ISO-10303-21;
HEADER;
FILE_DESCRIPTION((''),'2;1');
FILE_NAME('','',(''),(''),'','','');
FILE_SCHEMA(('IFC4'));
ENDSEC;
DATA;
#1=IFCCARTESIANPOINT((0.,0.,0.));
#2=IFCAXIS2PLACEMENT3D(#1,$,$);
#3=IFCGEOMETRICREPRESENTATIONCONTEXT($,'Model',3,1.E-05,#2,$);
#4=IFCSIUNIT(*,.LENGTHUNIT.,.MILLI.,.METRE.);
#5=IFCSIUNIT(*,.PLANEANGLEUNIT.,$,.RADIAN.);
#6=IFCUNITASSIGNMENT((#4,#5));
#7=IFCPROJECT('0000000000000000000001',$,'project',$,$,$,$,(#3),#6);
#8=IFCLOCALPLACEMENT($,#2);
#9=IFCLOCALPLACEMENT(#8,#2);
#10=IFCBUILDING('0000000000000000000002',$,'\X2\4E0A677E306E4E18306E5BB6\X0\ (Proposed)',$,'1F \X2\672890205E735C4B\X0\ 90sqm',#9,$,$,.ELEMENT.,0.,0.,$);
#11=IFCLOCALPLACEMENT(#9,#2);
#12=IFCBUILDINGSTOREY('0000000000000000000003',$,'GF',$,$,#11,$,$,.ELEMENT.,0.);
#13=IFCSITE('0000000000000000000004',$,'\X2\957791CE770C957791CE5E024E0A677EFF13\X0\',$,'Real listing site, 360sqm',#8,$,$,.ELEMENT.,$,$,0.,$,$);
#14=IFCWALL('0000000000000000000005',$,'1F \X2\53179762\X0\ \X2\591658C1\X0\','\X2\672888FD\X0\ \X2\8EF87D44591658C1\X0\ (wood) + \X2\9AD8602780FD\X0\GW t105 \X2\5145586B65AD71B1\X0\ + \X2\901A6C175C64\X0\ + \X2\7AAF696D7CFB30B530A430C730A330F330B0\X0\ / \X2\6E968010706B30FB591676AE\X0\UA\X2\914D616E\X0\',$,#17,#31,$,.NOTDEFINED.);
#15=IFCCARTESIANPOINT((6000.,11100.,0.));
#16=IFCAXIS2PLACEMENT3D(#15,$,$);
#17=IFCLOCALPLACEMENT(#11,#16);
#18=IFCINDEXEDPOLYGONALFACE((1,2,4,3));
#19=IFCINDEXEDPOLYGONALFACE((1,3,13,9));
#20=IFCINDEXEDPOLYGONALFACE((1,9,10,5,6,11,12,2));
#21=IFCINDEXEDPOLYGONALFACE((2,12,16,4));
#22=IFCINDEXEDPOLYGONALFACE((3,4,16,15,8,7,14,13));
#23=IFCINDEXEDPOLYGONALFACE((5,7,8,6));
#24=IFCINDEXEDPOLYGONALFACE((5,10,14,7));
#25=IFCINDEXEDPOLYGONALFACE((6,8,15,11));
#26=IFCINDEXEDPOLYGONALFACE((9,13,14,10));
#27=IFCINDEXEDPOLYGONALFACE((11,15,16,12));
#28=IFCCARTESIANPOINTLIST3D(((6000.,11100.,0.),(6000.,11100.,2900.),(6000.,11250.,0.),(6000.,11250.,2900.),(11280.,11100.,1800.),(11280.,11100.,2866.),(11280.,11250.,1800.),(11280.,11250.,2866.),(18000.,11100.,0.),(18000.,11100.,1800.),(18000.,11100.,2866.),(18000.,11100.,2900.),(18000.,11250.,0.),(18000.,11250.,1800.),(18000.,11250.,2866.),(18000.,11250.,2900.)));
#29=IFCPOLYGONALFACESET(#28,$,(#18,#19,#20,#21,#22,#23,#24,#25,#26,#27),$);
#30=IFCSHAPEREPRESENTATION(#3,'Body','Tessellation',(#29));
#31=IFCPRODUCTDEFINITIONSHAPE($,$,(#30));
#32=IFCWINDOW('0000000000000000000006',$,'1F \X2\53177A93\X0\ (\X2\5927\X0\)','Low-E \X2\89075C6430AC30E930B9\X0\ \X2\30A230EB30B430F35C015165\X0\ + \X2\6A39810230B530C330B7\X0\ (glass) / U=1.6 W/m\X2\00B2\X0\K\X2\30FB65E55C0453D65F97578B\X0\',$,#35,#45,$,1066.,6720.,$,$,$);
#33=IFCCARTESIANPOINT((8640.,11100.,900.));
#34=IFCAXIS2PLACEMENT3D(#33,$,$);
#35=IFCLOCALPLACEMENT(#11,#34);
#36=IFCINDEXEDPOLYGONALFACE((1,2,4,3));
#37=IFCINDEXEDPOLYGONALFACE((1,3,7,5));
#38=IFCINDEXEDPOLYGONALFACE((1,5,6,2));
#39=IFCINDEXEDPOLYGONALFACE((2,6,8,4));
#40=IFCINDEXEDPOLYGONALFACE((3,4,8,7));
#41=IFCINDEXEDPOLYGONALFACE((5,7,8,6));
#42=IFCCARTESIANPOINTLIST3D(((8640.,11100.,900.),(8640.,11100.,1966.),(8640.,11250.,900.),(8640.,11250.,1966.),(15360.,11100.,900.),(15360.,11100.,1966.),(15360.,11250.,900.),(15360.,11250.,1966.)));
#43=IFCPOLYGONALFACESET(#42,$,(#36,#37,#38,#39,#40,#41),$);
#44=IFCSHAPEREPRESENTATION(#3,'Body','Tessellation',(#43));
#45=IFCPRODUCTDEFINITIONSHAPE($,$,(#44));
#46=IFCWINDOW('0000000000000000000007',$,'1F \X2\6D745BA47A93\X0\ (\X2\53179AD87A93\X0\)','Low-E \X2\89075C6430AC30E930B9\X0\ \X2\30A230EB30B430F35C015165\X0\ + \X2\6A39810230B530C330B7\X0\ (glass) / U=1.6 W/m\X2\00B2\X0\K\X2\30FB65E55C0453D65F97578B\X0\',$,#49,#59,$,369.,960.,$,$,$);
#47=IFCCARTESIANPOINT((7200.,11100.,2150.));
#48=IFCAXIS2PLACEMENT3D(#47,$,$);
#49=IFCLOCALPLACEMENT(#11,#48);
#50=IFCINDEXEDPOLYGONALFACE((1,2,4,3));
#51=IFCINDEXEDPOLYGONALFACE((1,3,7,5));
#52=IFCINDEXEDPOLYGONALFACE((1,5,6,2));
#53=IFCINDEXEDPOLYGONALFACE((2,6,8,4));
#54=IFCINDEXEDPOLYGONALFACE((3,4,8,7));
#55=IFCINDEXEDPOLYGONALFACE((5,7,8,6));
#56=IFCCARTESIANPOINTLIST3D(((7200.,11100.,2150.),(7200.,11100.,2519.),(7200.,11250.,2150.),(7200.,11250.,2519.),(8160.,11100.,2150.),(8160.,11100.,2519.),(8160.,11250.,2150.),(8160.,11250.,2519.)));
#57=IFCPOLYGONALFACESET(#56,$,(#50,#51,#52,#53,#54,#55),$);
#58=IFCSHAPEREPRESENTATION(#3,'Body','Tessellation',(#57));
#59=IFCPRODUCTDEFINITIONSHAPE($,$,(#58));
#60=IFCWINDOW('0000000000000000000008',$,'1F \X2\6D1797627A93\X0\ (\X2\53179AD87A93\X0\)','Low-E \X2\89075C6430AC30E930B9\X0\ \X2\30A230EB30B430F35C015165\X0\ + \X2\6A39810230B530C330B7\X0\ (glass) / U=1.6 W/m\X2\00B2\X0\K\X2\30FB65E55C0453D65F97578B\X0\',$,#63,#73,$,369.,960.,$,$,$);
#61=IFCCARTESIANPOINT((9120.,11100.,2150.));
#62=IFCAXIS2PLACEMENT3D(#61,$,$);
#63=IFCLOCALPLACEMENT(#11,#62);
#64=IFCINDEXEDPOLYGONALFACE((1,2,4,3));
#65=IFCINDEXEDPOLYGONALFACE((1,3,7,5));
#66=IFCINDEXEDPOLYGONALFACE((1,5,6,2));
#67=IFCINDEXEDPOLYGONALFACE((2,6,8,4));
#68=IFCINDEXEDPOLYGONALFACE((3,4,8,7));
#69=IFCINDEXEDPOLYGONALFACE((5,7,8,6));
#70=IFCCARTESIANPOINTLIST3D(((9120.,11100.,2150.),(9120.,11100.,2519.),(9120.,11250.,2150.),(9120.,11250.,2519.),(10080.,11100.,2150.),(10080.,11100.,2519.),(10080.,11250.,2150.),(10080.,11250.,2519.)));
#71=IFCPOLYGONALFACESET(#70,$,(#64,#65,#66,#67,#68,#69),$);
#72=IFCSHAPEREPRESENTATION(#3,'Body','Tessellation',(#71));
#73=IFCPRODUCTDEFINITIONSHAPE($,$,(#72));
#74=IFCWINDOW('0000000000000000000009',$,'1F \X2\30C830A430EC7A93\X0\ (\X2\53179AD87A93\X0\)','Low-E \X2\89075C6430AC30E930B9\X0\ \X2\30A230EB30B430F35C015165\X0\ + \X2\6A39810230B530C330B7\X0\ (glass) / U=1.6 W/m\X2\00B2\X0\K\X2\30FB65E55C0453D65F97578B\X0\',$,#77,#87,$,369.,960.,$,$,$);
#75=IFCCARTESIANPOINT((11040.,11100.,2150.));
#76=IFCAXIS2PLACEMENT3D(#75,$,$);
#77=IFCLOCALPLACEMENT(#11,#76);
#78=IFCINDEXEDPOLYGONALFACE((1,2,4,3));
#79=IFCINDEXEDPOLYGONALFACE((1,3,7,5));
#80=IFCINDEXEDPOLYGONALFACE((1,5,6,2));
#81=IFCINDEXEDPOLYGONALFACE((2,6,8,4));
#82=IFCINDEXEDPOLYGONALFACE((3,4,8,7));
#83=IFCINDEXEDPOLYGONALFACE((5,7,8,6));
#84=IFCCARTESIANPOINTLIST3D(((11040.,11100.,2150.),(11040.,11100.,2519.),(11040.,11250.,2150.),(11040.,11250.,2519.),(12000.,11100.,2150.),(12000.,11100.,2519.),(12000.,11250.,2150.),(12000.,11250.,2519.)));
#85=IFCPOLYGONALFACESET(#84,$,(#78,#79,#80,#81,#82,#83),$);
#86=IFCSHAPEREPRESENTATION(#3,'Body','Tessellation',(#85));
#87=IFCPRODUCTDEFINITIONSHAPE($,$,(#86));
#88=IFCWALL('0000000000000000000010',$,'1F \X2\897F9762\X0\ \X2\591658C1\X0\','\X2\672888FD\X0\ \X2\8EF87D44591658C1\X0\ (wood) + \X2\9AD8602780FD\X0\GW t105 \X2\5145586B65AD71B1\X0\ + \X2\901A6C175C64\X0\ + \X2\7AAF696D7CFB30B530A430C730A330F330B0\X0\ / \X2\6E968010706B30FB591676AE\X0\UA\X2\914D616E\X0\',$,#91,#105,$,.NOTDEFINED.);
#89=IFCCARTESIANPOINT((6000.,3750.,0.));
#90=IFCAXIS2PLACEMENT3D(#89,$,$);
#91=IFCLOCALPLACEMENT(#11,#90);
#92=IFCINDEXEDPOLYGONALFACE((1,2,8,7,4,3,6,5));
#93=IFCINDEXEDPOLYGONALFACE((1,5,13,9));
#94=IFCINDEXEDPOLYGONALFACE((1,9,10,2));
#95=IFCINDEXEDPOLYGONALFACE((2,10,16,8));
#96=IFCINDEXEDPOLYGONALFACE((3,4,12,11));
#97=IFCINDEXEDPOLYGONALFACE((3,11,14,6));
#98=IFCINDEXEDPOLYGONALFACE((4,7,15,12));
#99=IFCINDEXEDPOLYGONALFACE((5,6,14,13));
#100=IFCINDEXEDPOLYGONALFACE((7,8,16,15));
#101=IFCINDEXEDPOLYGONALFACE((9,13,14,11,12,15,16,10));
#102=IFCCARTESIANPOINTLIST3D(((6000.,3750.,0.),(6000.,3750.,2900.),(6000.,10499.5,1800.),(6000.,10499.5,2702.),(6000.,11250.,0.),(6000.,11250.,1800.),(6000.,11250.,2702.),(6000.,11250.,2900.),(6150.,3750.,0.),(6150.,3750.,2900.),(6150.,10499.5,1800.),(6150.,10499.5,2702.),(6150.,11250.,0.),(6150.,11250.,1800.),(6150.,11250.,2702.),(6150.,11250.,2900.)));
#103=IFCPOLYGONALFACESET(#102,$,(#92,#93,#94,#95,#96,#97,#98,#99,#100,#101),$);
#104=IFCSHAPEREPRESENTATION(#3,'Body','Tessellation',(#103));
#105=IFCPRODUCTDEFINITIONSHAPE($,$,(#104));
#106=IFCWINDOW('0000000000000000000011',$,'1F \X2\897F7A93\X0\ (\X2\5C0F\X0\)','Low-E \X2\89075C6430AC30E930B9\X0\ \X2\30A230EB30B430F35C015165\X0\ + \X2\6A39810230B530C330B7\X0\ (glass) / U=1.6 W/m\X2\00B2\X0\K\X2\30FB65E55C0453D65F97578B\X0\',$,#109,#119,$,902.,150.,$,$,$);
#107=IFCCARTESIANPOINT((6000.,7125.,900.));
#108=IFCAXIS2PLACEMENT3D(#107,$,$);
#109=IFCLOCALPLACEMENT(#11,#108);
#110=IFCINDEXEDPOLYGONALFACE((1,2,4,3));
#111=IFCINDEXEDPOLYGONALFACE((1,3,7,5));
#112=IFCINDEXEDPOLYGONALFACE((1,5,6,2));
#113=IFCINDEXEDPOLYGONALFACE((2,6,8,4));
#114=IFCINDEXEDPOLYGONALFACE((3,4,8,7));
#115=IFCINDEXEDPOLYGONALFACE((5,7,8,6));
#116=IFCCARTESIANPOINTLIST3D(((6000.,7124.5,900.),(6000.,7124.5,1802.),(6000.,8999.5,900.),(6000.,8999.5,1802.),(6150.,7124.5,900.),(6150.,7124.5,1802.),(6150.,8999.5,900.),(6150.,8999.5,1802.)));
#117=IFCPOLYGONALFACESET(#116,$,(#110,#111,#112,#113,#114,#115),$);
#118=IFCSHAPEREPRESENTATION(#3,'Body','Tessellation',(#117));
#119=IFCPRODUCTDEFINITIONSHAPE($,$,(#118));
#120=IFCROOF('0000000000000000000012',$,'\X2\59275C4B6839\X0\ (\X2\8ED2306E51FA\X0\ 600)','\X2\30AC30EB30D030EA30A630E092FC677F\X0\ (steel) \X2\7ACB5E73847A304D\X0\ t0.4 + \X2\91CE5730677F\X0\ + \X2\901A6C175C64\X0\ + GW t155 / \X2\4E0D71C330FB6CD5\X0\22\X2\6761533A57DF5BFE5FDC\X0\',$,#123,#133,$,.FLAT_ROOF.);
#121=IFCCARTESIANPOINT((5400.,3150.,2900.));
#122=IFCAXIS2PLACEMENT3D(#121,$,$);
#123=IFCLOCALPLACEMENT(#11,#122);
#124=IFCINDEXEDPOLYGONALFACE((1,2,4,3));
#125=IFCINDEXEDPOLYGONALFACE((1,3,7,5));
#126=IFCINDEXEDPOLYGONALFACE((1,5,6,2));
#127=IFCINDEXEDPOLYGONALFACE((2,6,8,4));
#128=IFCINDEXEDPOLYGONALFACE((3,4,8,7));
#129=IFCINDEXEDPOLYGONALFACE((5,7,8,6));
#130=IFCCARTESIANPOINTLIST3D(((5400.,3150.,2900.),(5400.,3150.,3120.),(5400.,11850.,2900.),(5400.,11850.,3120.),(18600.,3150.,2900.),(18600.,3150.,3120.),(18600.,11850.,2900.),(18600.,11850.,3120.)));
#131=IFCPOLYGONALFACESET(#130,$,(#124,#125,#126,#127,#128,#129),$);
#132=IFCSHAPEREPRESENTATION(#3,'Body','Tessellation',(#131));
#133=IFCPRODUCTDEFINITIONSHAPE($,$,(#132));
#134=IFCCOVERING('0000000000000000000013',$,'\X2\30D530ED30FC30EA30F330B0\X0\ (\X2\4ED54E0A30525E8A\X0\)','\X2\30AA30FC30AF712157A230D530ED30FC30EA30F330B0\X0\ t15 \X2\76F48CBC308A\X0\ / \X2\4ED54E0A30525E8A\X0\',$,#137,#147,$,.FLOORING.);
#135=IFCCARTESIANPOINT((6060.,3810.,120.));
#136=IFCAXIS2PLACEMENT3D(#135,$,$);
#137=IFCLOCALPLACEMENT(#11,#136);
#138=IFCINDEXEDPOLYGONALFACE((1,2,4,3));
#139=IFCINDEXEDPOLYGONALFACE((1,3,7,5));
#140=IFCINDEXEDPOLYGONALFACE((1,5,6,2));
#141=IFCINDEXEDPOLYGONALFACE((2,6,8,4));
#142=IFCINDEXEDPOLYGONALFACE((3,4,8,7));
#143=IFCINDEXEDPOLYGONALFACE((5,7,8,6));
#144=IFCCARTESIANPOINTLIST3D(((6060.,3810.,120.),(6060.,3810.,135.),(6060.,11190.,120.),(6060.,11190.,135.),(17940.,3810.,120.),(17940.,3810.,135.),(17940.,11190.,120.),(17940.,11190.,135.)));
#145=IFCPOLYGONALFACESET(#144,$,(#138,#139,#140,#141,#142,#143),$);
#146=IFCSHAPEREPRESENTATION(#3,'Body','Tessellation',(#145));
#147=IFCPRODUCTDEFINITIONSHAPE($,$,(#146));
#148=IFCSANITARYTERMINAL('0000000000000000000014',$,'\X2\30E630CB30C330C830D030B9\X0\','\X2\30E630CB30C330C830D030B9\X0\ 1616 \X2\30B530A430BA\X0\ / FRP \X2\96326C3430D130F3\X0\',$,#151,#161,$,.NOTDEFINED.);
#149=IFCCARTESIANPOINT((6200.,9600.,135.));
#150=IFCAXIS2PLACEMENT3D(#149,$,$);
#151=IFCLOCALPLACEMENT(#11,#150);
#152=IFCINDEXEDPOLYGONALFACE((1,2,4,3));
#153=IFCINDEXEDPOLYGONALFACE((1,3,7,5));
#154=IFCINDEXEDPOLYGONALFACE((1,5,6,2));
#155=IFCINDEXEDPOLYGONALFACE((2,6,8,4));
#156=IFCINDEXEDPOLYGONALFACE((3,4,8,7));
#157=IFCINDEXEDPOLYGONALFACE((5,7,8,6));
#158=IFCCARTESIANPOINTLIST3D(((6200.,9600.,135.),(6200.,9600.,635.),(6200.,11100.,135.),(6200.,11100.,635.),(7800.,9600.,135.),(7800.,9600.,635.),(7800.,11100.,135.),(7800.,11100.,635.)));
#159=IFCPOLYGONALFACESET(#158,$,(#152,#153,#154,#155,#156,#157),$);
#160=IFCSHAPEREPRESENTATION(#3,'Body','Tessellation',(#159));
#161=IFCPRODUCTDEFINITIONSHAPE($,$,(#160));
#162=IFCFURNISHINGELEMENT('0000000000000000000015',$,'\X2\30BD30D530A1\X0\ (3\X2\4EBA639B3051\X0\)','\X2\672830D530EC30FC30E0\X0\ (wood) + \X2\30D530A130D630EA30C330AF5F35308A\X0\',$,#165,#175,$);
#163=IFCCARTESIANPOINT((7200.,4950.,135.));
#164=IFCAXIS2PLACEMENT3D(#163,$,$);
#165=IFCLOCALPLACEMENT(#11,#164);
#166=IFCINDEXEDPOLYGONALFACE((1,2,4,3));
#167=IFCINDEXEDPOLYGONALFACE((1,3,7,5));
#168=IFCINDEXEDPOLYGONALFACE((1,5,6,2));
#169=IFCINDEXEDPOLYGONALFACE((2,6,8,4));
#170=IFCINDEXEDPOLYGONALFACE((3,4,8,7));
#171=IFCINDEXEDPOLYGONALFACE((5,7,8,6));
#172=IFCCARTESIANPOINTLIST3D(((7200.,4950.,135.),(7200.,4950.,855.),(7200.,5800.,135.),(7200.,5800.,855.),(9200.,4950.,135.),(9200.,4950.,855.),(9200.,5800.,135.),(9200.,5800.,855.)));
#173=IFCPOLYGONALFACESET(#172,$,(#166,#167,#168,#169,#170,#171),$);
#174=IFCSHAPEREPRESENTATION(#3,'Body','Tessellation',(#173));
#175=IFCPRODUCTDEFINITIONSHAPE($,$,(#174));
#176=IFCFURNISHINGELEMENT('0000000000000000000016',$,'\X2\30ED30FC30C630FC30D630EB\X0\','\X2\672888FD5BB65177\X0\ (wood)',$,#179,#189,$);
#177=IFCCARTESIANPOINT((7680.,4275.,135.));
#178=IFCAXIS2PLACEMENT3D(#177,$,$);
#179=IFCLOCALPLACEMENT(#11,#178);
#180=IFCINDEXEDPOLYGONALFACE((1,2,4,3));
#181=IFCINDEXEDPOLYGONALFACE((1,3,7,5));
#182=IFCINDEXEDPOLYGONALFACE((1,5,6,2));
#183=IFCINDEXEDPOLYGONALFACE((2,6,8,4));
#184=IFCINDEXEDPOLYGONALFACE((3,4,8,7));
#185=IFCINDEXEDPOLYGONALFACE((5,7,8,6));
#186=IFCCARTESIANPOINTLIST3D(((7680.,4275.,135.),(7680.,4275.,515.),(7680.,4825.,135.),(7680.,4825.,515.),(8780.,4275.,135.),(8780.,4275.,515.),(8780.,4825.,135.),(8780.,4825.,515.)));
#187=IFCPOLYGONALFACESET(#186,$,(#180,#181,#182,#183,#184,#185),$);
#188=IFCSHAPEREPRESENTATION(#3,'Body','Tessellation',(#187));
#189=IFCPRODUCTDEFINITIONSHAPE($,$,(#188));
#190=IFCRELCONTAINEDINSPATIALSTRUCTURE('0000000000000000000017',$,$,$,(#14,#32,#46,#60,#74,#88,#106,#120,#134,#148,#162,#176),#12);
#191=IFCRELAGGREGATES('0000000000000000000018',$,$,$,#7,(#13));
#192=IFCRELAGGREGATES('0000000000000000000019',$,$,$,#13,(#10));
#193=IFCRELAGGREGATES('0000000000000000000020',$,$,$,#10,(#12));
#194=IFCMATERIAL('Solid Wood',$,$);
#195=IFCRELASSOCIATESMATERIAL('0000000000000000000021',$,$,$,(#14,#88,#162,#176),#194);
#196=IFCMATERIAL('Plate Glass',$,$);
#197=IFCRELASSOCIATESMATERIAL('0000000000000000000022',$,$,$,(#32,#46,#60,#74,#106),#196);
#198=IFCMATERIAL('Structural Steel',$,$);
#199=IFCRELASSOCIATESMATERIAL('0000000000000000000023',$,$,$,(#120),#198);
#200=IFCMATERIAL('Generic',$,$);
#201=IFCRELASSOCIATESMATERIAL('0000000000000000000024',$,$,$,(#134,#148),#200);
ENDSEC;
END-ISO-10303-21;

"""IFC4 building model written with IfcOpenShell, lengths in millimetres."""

from ifc_helpers import new_model, si_unit, frame, frame_2d, origin, place, context, project, spatial, rectangle, extrude, material, element, fill, save


model = new_model("IFC4")

# Units and contexts
model_context = context("Model", 3, precision=1e-05, world=origin())
ifc_project = project(units=[si_unit("LENGTHUNIT", "METRE", prefix="MILLI"), si_unit("PLANEANGLEUNIT", "RADIAN")], contexts=[model_context])

# Site, building, storey
site_placement = place(None, origin())
site = spatial("IfcSite", under=ifc_project, at=site_placement, Name="長野県長野市上松３", ObjectType="Real listing site, 360sqm", CompositionType="ELEMENT", RefElevation=0.0)
building_placement = place(site_placement, origin())
building = spatial("IfcBuilding", under=site, at=building_placement, Name="上松の丘の家 (Proposed)", ObjectType="1F 木造平屋 90sqm", CompositionType="ELEMENT", ElevationOfRefHeight=0.0, ElevationOfTerrain=0.0)
storey_placement = place(building_placement, origin())
storey = spatial("IfcBuildingStorey", under=building, at=storey_placement, Name="GF", CompositionType="ELEMENT", Elevation=0.0)

# Shared definitions
ifc_material_1 = material(Name="Solid Wood")

# Shared definitions
ifc_material_2 = material(Name="Plate Glass")

# Wall, openings, windows
wall_1_placement = place(storey_placement, frame((6000.0, 11100.0, 0.0)))
wall_1 = element("IfcWall", 1, at=wall_1_placement, inside=storey, material=ifc_material_1, Name="1F 北面 外壁", Description="木製 軸組外壁 (wood) + 高性能GW t105 充填断熱 + 通気層 + 窯業系サイディング / 準耐火・外皮UA配慮", PredefinedType="NOTDEFINED", context=model_context, shape_type="SweptSolid", body=[
    extrude(rectangle(XDim=12000.0, YDim=150.0, at=frame_2d((6000.0, 75.0))), frame((6000.0, 11100.0, 0.0)), (0.0, 0.0, 1.0), 2900.0),
])
opening_1_placement = place(storey_placement, frame((8640.0, 11100.0, 900.0)))
opening_1 = element("IfcOpeningElement", 2, at=opening_1_placement, cuts=wall_1, PredefinedType="NOTDEFINED", context=model_context, shape_type="SweptSolid", body=[
    extrude(rectangle(XDim=6720.0, YDim=150.0, at=frame_2d((3360.0, 75.0))), frame((8640.0, 11100.0, 900.0)), (0.0, 0.0, 1.0), 1066.0),
])
opening_2_placement = place(storey_placement, frame((7200.0, 11100.0, 2150.0)))
opening_2 = element("IfcOpeningElement", 3, at=opening_2_placement, cuts=wall_1, PredefinedType="NOTDEFINED", context=model_context, shape_type="SweptSolid", body=[
    extrude(rectangle(XDim=960.0, YDim=150.0, at=frame_2d((480.0, 75.0))), frame((7200.0, 11100.0, 2150.0)), (0.0, 0.0, 1.0), 369.0),
])
opening_3_placement = place(storey_placement, frame((9120.0, 11100.0, 2150.0)))
opening_3 = element("IfcOpeningElement", 4, at=opening_3_placement, cuts=wall_1, PredefinedType="NOTDEFINED", context=model_context, shape_type="SweptSolid", body=[
    extrude(rectangle(XDim=960.0, YDim=150.0, at=frame_2d((480.0, 75.0))), frame((9120.0, 11100.0, 2150.0)), (0.0, 0.0, 1.0), 369.0),
])
opening_4_placement = place(storey_placement, frame((11040.0, 11100.0, 2150.0)))
opening_4 = element("IfcOpeningElement", 5, at=opening_4_placement, cuts=wall_1, PredefinedType="NOTDEFINED", context=model_context, shape_type="SweptSolid", body=[
    extrude(rectangle(XDim=960.0, YDim=150.0, at=frame_2d((480.0, 75.0))), frame((11040.0, 11100.0, 2150.0)), (0.0, 0.0, 1.0), 369.0),
])
window_1_placement = place(storey_placement, frame((8640.0, 11100.0, 900.0)))
window_1 = element("IfcWindow", 6, at=window_1_placement, inside=storey, material=ifc_material_2, Name="1F 北窓 (大)", Description="Low-E 複層ガラス アルゴン封入 + 樹脂サッシ (glass) / U=1.6 W/m²K・日射取得型", OverallHeight=1066.0, OverallWidth=6720.0, context=model_context, shape_type="SweptSolid", body=[
    extrude(rectangle(XDim=6720.0, YDim=150.0, at=frame_2d((3360.0, 75.0))), frame((8640.0, 11100.0, 900.0)), (0.0, 0.0, 1.0), 1066.0),
])
fill(opening_1, window_1)
window_2_placement = place(storey_placement, frame((7200.0, 11100.0, 2150.0)))
window_2 = element("IfcWindow", 7, at=window_2_placement, inside=storey, material=ifc_material_2, Name="1F 浴室窓 (北高窓)", Description="Low-E 複層ガラス アルゴン封入 + 樹脂サッシ (glass) / U=1.6 W/m²K・日射取得型", OverallHeight=369.0, OverallWidth=960.0, context=model_context, shape_type="SweptSolid", body=[
    extrude(rectangle(XDim=960.0, YDim=150.0, at=frame_2d((480.0, 75.0))), frame((7200.0, 11100.0, 2150.0)), (0.0, 0.0, 1.0), 369.0),
])
fill(opening_2, window_2)
window_3_placement = place(storey_placement, frame((9120.0, 11100.0, 2150.0)))
window_3 = element("IfcWindow", 8, at=window_3_placement, inside=storey, material=ifc_material_2, Name="1F 洗面窓 (北高窓)", Description="Low-E 複層ガラス アルゴン封入 + 樹脂サッシ (glass) / U=1.6 W/m²K・日射取得型", OverallHeight=369.0, OverallWidth=960.0, context=model_context, shape_type="SweptSolid", body=[
    extrude(rectangle(XDim=960.0, YDim=150.0, at=frame_2d((480.0, 75.0))), frame((9120.0, 11100.0, 2150.0)), (0.0, 0.0, 1.0), 369.0),
])
fill(opening_3, window_3)
window_4_placement = place(storey_placement, frame((11040.0, 11100.0, 2150.0)))
window_4 = element("IfcWindow", 9, at=window_4_placement, inside=storey, material=ifc_material_2, Name="1F トイレ窓 (北高窓)", Description="Low-E 複層ガラス アルゴン封入 + 樹脂サッシ (glass) / U=1.6 W/m²K・日射取得型", OverallHeight=369.0, OverallWidth=960.0, context=model_context, shape_type="SweptSolid", body=[
    extrude(rectangle(XDim=960.0, YDim=150.0, at=frame_2d((480.0, 75.0))), frame((11040.0, 11100.0, 2150.0)), (0.0, 0.0, 1.0), 369.0),
])
fill(opening_4, window_4)

# Wall, opening, window
wall_2_placement = place(storey_placement, frame((6000.0, 3750.0, 0.0)))
wall_2 = element("IfcWall", 10, at=wall_2_placement, inside=storey, material=ifc_material_1, Name="1F 西面 外壁", Description="木製 軸組外壁 (wood) + 高性能GW t105 充填断熱 + 通気層 + 窯業系サイディング / 準耐火・外皮UA配慮", PredefinedType="NOTDEFINED", context=model_context, shape_type="SweptSolid", body=[
    extrude(rectangle(XDim=150.0, YDim=7500.0, at=frame_2d((75.0, 3750.0))), frame((6000.0, 3750.0, 0.0)), (0.0, 0.0, 1.0), 2900.0),
])
opening_5_placement = place(storey_placement, frame((6000.0, 7125.0, 900.0)))
opening_5 = element("IfcOpeningElement", 11, at=opening_5_placement, cuts=wall_2, PredefinedType="NOTDEFINED", context=model_context, shape_type="SweptSolid", body=[
    extrude(rectangle(XDim=150.0, YDim=1875.0, at=frame_2d((75.0, 937.0))), frame((6000.0, 7125.0, 900.0)), (0.0, 0.0, 1.0), 902.0),
])
window_5_placement = place(storey_placement, frame((6000.0, 7125.0, 900.0)))
window_5 = element("IfcWindow", 12, at=window_5_placement, inside=storey, material=ifc_material_2, Name="1F 西窓 (小)", Description="Low-E 複層ガラス アルゴン封入 + 樹脂サッシ (glass) / U=1.6 W/m²K・日射取得型", OverallHeight=902.0, OverallWidth=150.0, context=model_context, shape_type="SweptSolid", body=[
    extrude(rectangle(XDim=150.0, YDim=1875.0, at=frame_2d((75.0, 937.0))), frame((6000.0, 7125.0, 900.0)), (0.0, 0.0, 1.0), 902.0),
])
fill(opening_5, window_5)

# Roof
ifc_material_3 = material(Name="Structural Steel")
roof_placement = place(storey_placement, frame((5400.0, 3150.0, 2900.0)))
element("IfcRoof", 13, at=roof_placement, inside=storey, material=ifc_material_3, Name="大屋根 (軒の出 600)", Description="ガルバリウム鋼板 (steel) 立平葺き t0.4 + 野地板 + 通気層 + GW t155 / 不燃・法22条区域対応", PredefinedType="FLAT_ROOF", context=model_context, shape_type="SweptSolid", body=[
    extrude(rectangle(XDim=13200.0, YDim=8700.0, at=frame_2d((6600.0, 4350.0))), frame((5400.0, 3150.0, 2900.0)), (0.0, 0.0, 1.0), 220.0),
])

# Covering
ifc_material_4 = material(Name="Generic")
covering_placement = place(storey_placement, frame((6060.0, 3810.0, 120.0)))
element("IfcCovering", 14, at=covering_placement, inside=storey, material=ifc_material_4, Name="フローリング (仕上げ床)", Description="オーク無垢フローリング t15 直貼り / 仕上げ床", PredefinedType="FLOORING", context=model_context, shape_type="SweptSolid", body=[
    extrude(rectangle(XDim=11880.0, YDim=7380.0, at=frame_2d((5940.0, 3690.0))), frame((6060.0, 3810.0, 120.0)), (0.0, 0.0, 1.0), 15.0),
])

# Sanitary terminal
sanitary_terminal_placement = place(storey_placement, frame((6200.0, 9600.0, 135.0)))
element("IfcSanitaryTerminal", 15, at=sanitary_terminal_placement, inside=storey, material=ifc_material_4, Name="ユニットバス", Description="ユニットバス 1616 サイズ / FRP 防水パン", PredefinedType="NOTDEFINED", context=model_context, shape_type="SweptSolid", body=[
    extrude(rectangle(XDim=1600.0, YDim=1500.0, at=frame_2d((800.0, 750.0))), frame((6200.0, 9600.0, 135.0)), (0.0, 0.0, 1.0), 500.0),
])

# Furnishing elements
furnishing_1_placement = place(storey_placement, frame((7200.0, 4950.0, 135.0)))
element("IfcFurnishingElement", 16, at=furnishing_1_placement, inside=storey, material=ifc_material_1, Name="ソファ (3人掛け)", Description="木フレーム (wood) + ファブリック張り", context=model_context, shape_type="SweptSolid", body=[
    extrude(rectangle(XDim=2000.0, YDim=850.0, at=frame_2d((1000.0, 425.0))), frame((7200.0, 4950.0, 135.0)), (0.0, 0.0, 1.0), 720.0),
])
furnishing_2_placement = place(storey_placement, frame((7680.0, 4275.0, 135.0)))
element("IfcFurnishingElement", 17, at=furnishing_2_placement, inside=storey, material=ifc_material_1, Name="ローテーブル", Description="木製家具 (wood)", context=model_context, shape_type="SweptSolid", body=[
    extrude(rectangle(XDim=1100.0, YDim=550.0, at=frame_2d((550.0, 275.0))), frame((7680.0, 4275.0, 135.0)), (0.0, 0.0, 1.0), 380.0),
])

save(model, "model.ifc")
